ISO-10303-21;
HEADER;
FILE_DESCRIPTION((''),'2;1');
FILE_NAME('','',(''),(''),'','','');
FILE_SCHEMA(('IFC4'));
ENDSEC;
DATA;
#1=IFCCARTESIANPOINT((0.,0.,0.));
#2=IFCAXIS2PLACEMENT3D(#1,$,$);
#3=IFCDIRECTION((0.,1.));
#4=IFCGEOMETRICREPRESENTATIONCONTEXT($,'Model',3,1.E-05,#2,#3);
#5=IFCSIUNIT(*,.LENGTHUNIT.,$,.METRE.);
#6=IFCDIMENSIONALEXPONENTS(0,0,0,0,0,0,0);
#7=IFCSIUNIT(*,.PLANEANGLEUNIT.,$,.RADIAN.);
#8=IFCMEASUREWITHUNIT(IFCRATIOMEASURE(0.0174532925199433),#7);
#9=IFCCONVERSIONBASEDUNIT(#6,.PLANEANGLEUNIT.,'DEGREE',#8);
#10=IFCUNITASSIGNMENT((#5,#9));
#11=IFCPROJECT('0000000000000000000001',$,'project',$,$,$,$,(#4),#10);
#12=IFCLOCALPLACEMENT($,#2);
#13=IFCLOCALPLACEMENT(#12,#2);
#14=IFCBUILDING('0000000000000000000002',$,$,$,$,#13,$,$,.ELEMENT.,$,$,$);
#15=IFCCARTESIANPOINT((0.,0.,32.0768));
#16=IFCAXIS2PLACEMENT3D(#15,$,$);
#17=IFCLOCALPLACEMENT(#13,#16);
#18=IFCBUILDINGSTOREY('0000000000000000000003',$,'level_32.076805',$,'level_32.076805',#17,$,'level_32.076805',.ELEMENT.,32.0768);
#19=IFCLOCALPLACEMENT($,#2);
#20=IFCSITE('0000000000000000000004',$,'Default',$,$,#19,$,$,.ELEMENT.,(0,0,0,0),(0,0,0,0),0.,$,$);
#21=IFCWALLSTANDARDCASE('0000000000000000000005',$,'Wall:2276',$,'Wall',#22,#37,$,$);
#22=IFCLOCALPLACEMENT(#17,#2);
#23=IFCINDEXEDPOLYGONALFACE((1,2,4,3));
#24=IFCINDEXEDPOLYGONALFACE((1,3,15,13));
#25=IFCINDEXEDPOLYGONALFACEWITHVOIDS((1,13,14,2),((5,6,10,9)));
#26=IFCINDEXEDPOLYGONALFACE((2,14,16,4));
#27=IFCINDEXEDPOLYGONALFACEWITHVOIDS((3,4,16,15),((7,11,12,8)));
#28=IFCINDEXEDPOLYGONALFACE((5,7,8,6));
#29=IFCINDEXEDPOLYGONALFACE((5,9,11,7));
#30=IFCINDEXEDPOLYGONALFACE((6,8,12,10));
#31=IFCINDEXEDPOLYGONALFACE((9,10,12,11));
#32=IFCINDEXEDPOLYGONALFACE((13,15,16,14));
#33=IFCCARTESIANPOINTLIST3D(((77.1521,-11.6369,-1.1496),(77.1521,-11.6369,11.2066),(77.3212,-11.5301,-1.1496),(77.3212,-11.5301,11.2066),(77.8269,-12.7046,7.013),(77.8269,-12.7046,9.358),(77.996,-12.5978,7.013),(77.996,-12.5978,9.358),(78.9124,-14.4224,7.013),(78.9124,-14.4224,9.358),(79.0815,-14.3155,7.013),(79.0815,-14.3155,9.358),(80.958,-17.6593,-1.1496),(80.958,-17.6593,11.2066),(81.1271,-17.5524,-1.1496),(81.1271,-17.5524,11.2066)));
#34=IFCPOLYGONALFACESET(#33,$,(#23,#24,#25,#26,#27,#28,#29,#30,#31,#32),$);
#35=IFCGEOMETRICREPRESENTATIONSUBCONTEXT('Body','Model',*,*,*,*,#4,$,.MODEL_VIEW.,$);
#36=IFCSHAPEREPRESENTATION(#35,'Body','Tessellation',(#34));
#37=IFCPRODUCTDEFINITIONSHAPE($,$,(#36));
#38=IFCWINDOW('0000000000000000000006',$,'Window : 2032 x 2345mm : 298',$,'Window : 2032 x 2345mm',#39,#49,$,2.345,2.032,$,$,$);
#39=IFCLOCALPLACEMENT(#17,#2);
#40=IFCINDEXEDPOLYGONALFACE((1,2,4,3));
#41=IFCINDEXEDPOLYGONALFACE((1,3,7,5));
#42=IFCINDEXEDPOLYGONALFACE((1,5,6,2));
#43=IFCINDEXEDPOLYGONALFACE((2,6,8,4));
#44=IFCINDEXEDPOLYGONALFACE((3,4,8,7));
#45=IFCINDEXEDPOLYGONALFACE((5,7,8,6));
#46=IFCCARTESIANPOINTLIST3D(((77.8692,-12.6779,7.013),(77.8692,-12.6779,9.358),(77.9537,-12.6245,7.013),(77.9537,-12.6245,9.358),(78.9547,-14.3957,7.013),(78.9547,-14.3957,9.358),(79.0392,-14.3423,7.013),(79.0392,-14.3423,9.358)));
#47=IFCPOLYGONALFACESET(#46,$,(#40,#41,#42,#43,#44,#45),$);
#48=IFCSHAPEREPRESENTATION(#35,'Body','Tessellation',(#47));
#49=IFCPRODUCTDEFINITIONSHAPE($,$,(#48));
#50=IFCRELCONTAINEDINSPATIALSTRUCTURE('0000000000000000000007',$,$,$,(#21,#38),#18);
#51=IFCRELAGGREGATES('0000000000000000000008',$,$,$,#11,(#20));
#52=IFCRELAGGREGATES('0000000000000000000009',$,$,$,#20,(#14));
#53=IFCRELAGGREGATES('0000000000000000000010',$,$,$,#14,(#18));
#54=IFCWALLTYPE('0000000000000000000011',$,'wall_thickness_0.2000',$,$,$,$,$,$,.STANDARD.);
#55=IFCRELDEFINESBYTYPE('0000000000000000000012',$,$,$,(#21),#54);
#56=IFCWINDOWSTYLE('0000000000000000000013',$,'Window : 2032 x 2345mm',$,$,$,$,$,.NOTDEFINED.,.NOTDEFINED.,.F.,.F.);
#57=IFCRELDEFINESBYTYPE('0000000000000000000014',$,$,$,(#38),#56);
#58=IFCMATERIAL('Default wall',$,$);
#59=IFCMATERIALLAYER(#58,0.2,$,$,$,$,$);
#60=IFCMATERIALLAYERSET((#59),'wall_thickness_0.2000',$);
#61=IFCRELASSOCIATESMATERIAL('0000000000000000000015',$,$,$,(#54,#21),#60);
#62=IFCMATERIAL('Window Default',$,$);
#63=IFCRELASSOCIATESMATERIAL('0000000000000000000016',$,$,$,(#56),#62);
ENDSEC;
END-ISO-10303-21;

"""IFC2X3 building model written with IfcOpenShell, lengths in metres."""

from ifc_helpers import new_model, entity, si_unit, converted_unit, direction, frame, frame_2d, origin, origin_2d_with_axis, place, context, subcontext, project, spatial, polyline, rectangle, outline, extrude, source, transform, mapped, material, layer, layer_set, layer_usage, type_object, type_shapes, element, fill, save


model = new_model("IFC2X3")

# Units and contexts
model_context = context("Model", 3, precision=1e-05, world=origin(), true_north=direction((0.0, 1.0)))
body_context = subcontext(model_context, "Body", "Model", "MODEL_VIEW")
ifc_project = project(units=[si_unit("LENGTHUNIT", "METRE"), converted_unit("PLANEANGLEUNIT", "DEGREE", entity("IfcRatioMeasure", 0.0174532925199433), si_unit("PLANEANGLEUNIT", "RADIAN"), dimensions=[0, 0, 0, 0, 0, 0, 0])], contexts=[model_context])

# Site, building, storey
site_placement = place(None, origin())
site = spatial("IfcSite", under=ifc_project, at=site_placement, Name="Default", CompositionType="ELEMENT", RefLatitude=(0, 0, 0, 0), RefLongitude=(0, 0, 0, 0), RefElevation=0.0)
placement_1 = place(None, origin())
building_placement = place(placement_1, origin())
building = spatial("IfcBuilding", under=site, at=building_placement, CompositionType="ELEMENT")
storey_placement = place(building_placement, frame((0.0, 0.0, 32.0768)))
storey = spatial("IfcBuildingStorey", under=building, at=storey_placement, Name="level_32.076805", ObjectType="level_32.076805", LongName="level_32.076805", CompositionType="ELEMENT", Elevation=32.0768)

# Shared definitions
ifc_material_1 = material(Name="Default wall")
ifc_layer = layer(ifc_material_1, 0.2)
ifc_layer_set = layer_set([ifc_layer], Name="wall_thickness_0.2000")
ifc_layer_usage = layer_usage(ifc_layer_set, "AXIS2", "POSITIVE", -0.1)
wall_type = type_object("IfcWallType", Name="wall_thickness_0.2000", PredefinedType="STANDARD", material=ifc_layer_set)

# Shared definitions
ifc_material_2 = material(Name="Window Default")

# Wall, opening, window
placement_2 = place(building_placement, frame((0.0, 0.0, 30.9272)))
wall_1_placement = place(placement_2, frame((81.0425, -17.6059, 0.0), z_axis=(0.0, 0.0, 1.0), x_axis=(-0.534219, 0.845346, 0.0)))
wall_1 = element("IfcWallStandardCase", 1, at=wall_1_placement, inside=storey, type_object=wall_type, material=ifc_layer_usage, Name="Wall:2276", ObjectType="Wall", context=body_context, shape_type="SweptSolid", body=[
    extrude(outline(polyline([(7.1242, -0.1), (7.1242, 0.1), (0.0, 0.1), (0.0, -0.1), (7.1242, -0.1)])), origin(), (0.0, 0.0, 1.0), 12.3563),
])
opening_1_placement = place(wall_1_placement, frame((3.8291, -0.1, 8.1626)))
opening_1 = element("IfcOpeningElement", 2, at=opening_1_placement, cuts=wall_1, ObjectType="Opening", context=body_context, shape_type="SweptSolid", body=[
    extrude(rectangle(XDim=2.032, YDim=2.345, at=frame_2d((1.1725, 1.016), x_axis=(0.0, 1.0))), frame((0.0, 0.0, 0.0), z_axis=(0.0, 1.0, 0.0), x_axis=(0.0, 0.0, 1.0)), (0.0, 0.0, 1.0), 0.2),
])
window_style_1 = type_object("IfcWindowStyle", Name="Window : 2032 x 2345mm", ConstructionType="NOTDEFINED", OperationType="NOTDEFINED", ParameterTakesPrecedence=False, Sizeable=False, material=ifc_material_2)
shared_shape_1 = source(origin(), body_context, "Body", "SweptSolid", [
    extrude(rectangle(XDim=0.1, YDim=2.032, at=origin_2d_with_axis()), frame((1.016, 0.1, 0.0), z_axis=(0.0, 0.0, 1.0), x_axis=(0.0, 1.0, 0.0)), (0.0, 0.0, 1.0), 2.345),
])
type_shapes(window_style_1, [shared_shape_1])
window_1_placement = place(opening_1_placement, origin())
window_1 = element("IfcWindow", 3, at=window_1_placement, inside=storey, type_object=window_style_1, Name="Window : 2032 x 2345mm : 298", ObjectType="Window : 2032 x 2345mm", OverallHeight=2.345, OverallWidth=2.032, context=body_context, shape_type="MappedRepresentation", body=[
    mapped(shared_shape_1, transform((0.0, 0.0, 0.0), scale=1.0)),
])
fill(opening_1, window_1)

save(model, "model.ifc")
